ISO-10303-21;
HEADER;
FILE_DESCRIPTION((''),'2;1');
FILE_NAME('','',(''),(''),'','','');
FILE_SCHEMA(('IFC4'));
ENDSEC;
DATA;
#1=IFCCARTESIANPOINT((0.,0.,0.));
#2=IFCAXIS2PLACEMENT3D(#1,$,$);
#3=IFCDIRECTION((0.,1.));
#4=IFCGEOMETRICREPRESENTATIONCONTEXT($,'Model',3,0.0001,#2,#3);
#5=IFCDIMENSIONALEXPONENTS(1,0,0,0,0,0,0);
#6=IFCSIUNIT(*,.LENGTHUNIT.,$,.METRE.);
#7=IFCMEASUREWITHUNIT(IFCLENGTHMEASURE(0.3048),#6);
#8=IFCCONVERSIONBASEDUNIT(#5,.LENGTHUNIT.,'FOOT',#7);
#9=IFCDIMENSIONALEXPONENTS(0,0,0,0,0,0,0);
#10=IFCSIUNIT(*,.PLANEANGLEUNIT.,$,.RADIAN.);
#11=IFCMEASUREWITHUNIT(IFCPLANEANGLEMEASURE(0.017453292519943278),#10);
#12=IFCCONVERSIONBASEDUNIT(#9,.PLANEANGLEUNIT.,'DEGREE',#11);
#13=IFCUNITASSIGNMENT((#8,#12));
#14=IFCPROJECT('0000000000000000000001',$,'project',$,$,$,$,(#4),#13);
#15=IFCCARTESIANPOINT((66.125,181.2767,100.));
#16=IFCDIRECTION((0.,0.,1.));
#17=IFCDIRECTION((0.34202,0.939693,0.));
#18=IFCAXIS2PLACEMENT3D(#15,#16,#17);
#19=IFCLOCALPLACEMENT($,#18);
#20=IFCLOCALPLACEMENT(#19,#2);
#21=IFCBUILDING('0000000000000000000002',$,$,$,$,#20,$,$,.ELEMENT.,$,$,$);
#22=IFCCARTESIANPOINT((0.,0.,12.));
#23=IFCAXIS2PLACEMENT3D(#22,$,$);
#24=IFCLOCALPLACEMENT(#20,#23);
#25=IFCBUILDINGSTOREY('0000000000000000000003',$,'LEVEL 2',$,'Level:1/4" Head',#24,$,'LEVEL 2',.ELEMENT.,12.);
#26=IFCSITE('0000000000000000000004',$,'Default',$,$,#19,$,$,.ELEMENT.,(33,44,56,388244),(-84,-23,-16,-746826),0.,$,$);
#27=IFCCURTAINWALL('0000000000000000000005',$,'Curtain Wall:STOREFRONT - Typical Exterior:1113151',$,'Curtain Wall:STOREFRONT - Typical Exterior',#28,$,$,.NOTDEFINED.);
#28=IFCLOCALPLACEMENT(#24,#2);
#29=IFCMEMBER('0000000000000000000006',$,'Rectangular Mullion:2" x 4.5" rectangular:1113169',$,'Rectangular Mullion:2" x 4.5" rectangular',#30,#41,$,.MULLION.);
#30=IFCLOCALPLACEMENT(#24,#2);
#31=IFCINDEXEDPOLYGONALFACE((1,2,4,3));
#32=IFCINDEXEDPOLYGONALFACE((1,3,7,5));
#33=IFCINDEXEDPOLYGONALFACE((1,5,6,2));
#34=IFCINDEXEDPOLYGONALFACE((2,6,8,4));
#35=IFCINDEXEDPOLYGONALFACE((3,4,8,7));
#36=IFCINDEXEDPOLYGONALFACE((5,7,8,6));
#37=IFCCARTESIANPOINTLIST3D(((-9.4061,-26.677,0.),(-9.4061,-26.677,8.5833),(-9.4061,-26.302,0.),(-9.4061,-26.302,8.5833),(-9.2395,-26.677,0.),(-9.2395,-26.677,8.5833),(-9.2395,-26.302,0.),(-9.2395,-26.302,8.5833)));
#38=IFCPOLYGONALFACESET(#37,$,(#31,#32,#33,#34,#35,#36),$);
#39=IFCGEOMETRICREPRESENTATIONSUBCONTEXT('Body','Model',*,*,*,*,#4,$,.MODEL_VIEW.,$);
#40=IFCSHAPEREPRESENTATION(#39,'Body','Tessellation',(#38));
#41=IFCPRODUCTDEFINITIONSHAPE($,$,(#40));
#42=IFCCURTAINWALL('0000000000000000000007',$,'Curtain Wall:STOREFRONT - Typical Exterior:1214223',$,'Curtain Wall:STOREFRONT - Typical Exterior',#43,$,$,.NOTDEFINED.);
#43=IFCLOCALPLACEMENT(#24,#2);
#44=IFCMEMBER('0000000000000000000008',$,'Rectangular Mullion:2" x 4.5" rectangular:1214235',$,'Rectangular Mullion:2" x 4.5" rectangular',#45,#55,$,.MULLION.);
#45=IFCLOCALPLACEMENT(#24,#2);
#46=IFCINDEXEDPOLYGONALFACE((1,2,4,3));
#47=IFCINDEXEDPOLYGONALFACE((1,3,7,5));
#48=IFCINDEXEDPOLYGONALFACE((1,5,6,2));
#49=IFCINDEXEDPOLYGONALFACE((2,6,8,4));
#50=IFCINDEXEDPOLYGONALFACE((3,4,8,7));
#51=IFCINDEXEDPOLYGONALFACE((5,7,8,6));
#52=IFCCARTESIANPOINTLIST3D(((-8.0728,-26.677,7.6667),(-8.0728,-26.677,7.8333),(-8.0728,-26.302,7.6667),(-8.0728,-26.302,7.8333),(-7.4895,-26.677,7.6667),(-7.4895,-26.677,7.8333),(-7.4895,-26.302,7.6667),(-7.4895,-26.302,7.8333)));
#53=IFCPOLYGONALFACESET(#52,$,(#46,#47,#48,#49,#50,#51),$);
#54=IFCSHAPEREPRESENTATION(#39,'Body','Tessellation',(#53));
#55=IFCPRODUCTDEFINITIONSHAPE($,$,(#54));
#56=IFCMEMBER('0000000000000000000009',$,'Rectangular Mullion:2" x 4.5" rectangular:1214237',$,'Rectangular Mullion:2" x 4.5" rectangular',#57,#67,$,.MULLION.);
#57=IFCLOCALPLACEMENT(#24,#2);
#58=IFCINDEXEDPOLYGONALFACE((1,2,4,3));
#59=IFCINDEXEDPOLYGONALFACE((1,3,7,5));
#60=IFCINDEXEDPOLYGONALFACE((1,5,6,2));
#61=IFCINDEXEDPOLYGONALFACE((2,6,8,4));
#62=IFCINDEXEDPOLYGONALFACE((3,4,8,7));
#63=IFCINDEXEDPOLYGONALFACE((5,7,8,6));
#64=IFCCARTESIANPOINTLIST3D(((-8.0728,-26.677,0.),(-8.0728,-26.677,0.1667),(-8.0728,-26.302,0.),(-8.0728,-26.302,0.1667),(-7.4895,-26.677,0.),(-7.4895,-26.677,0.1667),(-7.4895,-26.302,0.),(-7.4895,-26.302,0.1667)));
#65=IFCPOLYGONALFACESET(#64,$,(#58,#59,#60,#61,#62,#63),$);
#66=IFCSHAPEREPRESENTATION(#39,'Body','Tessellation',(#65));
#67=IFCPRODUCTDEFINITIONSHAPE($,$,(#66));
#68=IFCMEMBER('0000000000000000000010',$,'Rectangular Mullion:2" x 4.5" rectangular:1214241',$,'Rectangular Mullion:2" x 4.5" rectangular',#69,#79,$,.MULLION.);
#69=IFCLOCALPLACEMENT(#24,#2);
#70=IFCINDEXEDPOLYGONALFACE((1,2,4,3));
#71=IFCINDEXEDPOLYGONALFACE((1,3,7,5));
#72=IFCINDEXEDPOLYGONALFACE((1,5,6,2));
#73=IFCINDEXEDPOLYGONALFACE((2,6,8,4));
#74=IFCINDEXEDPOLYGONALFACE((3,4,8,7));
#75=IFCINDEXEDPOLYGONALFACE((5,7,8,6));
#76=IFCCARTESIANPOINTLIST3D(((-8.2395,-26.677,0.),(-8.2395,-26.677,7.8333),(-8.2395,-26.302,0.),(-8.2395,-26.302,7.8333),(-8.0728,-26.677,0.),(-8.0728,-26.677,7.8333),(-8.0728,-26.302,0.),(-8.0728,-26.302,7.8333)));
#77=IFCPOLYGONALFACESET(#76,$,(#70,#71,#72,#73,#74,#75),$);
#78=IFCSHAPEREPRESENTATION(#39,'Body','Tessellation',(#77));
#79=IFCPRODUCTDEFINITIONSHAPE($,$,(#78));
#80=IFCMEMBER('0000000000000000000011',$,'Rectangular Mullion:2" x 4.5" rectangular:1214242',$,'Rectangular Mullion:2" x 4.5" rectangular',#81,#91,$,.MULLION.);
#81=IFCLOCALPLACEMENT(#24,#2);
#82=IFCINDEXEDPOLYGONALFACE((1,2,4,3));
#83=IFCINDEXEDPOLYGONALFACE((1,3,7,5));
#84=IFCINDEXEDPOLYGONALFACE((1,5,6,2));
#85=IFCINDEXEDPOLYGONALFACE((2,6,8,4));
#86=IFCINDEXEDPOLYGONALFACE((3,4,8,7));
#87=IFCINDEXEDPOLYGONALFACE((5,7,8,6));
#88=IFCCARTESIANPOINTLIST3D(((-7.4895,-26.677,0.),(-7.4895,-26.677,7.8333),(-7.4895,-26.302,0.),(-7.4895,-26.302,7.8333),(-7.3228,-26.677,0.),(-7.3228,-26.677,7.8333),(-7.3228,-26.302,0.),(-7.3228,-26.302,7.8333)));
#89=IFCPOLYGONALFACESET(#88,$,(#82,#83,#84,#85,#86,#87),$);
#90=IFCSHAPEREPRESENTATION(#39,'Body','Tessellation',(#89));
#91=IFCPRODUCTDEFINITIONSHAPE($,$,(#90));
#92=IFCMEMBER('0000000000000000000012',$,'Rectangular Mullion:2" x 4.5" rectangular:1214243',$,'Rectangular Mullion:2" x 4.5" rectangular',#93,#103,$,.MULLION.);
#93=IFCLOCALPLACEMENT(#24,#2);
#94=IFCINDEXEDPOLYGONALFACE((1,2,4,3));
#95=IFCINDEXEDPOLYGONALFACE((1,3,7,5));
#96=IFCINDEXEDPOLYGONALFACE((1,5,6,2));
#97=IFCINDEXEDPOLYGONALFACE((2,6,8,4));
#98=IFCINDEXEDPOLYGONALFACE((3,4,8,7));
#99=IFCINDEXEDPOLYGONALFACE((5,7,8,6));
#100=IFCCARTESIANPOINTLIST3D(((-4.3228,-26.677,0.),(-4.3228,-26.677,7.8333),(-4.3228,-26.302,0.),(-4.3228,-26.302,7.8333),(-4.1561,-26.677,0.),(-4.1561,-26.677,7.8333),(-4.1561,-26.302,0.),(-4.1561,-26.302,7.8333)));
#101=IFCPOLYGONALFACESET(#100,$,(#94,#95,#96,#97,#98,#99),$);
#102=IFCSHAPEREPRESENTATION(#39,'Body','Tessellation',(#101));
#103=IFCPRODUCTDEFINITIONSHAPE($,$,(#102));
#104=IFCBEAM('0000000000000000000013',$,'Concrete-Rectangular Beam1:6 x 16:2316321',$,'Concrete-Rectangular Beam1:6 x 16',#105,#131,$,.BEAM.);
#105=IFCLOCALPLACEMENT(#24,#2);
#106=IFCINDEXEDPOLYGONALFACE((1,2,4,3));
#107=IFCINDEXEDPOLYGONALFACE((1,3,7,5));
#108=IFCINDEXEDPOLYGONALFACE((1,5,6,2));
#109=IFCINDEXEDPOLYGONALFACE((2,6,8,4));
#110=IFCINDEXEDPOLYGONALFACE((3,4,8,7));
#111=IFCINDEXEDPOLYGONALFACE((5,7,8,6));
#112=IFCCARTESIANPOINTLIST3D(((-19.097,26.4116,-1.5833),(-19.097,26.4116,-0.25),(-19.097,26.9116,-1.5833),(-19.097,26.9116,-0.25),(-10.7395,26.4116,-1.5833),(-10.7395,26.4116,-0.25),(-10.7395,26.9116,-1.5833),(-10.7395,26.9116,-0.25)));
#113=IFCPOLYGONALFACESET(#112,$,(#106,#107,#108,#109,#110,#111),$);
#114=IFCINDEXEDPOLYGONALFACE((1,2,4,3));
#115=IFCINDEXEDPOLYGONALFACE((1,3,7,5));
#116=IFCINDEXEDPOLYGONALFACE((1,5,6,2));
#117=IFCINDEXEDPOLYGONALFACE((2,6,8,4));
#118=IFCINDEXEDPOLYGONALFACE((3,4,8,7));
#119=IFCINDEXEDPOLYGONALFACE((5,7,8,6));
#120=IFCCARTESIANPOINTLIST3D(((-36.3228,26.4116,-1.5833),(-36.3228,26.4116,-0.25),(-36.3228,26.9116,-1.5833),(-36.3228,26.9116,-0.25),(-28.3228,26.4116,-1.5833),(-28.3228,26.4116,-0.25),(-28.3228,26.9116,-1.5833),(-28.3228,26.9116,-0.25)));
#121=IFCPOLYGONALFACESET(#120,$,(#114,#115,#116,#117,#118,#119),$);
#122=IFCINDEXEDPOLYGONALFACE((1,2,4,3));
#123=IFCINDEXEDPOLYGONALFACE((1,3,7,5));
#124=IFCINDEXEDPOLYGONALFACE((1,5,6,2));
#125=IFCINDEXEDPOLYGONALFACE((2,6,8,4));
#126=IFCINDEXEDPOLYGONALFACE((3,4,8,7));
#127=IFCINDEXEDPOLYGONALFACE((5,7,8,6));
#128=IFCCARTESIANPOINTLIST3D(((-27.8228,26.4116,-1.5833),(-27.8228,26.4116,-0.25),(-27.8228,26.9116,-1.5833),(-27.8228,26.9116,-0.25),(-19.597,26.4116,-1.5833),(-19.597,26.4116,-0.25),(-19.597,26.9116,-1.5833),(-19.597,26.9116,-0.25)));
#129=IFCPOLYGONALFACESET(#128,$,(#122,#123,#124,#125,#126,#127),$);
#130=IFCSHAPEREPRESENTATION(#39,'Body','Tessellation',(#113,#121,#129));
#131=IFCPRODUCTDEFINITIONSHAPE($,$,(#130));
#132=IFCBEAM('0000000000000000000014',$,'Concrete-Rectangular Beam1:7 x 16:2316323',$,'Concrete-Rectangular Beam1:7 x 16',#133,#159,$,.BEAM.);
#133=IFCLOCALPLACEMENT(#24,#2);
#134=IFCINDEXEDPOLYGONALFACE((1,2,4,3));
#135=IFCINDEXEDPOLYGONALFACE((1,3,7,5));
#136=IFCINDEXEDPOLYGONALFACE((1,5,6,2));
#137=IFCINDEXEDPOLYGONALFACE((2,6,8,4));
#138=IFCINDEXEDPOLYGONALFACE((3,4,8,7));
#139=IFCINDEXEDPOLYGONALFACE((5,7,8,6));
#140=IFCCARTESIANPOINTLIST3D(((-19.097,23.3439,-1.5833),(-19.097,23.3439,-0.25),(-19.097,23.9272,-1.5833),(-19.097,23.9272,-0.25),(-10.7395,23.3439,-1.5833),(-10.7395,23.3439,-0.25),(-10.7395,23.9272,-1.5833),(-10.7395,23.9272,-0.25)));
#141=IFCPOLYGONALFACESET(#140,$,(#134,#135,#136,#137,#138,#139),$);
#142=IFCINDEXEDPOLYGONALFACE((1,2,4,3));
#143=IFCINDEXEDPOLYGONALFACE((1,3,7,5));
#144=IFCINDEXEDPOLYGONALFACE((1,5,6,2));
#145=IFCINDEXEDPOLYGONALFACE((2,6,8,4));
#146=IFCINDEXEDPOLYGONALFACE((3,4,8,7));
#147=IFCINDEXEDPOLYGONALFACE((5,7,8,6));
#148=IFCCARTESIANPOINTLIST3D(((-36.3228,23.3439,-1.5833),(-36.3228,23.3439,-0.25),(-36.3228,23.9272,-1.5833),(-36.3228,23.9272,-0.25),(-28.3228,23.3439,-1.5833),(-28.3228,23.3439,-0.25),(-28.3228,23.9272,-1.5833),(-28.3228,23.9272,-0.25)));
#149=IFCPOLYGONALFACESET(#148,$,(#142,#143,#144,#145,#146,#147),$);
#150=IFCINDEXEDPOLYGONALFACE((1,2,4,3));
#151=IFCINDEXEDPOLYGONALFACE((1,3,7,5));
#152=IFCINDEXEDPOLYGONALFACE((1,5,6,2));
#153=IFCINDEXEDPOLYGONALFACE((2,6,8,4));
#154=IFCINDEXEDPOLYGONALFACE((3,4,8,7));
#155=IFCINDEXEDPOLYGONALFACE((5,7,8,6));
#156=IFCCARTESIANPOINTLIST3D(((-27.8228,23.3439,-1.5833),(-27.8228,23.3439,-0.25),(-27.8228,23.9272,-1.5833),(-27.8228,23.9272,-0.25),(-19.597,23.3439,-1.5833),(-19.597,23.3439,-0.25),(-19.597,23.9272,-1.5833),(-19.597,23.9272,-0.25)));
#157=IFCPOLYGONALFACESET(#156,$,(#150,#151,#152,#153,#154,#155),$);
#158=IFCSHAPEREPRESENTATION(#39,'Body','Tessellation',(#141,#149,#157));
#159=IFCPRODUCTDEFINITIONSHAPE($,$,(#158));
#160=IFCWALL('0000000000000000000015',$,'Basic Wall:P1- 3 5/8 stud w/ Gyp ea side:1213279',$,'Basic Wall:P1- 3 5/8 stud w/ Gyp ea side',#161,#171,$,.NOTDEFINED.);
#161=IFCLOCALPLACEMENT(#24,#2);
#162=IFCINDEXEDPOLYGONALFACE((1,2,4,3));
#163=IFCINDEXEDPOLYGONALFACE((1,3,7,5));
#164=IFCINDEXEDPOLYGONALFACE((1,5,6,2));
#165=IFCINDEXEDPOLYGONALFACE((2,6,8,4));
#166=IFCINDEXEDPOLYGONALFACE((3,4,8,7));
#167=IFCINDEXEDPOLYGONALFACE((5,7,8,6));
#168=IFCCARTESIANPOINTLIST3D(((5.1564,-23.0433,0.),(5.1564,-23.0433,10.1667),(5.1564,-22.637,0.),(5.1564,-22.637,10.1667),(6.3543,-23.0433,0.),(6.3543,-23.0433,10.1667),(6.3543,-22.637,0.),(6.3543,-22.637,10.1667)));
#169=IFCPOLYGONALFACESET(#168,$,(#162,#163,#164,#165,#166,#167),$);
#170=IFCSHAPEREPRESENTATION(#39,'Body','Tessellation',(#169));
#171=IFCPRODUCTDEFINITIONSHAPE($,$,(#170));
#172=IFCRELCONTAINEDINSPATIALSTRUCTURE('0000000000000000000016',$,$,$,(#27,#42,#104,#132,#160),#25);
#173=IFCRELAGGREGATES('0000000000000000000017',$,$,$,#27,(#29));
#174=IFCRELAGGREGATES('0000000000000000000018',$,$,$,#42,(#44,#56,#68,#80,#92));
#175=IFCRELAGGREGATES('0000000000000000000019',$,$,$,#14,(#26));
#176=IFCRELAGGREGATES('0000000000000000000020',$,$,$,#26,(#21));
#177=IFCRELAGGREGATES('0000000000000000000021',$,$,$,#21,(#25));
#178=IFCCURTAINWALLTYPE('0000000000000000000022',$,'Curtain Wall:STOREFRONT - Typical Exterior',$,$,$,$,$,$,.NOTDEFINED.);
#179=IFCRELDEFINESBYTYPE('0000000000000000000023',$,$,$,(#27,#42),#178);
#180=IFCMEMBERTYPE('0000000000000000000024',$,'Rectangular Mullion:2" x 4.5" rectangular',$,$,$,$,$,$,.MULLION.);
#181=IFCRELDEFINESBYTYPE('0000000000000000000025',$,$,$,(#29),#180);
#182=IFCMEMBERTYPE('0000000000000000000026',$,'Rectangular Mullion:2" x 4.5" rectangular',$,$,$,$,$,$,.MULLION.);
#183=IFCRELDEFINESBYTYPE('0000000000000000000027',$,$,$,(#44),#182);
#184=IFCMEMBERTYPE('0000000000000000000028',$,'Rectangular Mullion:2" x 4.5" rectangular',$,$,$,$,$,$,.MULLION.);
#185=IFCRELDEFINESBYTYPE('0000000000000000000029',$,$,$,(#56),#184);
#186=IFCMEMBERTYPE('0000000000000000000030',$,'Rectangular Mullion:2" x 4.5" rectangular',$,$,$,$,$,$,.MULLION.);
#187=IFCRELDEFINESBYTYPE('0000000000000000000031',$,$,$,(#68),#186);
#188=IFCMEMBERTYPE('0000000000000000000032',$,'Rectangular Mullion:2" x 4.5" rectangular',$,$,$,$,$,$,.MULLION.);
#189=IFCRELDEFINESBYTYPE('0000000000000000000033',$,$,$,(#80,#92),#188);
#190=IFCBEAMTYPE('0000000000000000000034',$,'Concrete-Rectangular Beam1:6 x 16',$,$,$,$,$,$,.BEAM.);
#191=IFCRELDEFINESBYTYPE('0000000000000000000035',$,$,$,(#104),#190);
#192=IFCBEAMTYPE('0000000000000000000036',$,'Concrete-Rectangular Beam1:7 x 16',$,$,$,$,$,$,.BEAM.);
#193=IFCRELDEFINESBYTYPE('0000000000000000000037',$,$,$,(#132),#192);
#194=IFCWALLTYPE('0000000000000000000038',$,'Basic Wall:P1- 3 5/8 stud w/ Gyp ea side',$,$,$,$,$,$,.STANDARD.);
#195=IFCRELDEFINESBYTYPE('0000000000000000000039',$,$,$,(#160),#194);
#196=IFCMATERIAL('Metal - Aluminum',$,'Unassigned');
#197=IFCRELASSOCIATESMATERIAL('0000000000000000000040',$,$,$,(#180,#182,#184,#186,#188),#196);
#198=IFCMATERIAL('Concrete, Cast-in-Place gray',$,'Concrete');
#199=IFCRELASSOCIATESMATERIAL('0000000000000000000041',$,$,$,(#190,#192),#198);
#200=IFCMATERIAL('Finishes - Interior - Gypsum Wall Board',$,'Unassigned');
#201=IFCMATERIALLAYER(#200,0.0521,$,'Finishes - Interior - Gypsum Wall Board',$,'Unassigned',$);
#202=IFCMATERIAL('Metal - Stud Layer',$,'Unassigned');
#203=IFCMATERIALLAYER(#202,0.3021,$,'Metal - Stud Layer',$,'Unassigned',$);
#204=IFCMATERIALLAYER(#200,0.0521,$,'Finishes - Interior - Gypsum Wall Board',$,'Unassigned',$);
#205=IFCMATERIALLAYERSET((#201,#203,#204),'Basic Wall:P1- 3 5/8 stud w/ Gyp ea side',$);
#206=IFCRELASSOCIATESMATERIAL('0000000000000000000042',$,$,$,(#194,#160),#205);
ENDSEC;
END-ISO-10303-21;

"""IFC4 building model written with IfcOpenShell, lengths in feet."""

from ifc_helpers import new_model, entity, si_unit, converted_unit, direction, frame, frame_2d, origin, origin_2d_with_axis, place, context, subcontext, project, spatial, rectangle, extrude, source, transform, mapped, material, layer, layer_set, layer_usage, material_profile, profile_set, type_object, type_shapes, element, aggregate, save


model = new_model("IFC4")

# Units and contexts
model_context = context("Model", 3, precision=0.0001, world=origin(), true_north=direction((0.0, 1.0)))
body_context = subcontext(model_context, "Body", "Model", "MODEL_VIEW")
ifc_project = project(units=[converted_unit("LENGTHUNIT", "FOOT", entity("IfcLengthMeasure", 0.3048), si_unit("LENGTHUNIT", "METRE"), dimensions=[1, 0, 0, 0, 0, 0, 0]), converted_unit("PLANEANGLEUNIT", "DEGREE", entity("IfcPlaneAngleMeasure", 0.017453292519943278), si_unit("PLANEANGLEUNIT", "RADIAN"), dimensions=[0, 0, 0, 0, 0, 0, 0])], contexts=[model_context])

# Site, building, storey
site_placement = place(None, frame((66.125, 181.2767, 100.0), z_axis=(0.0, 0.0, 1.0), x_axis=(0.34202, 0.939693, 0.0)))
site = spatial("IfcSite", under=ifc_project, at=site_placement, Name="Default", CompositionType="ELEMENT", RefLatitude=(33, 44, 56, 388244), RefLongitude=(-84, -23, -16, -746826), RefElevation=0.0)
building_placement = place(site_placement, origin())
building = spatial("IfcBuilding", under=site, at=building_placement, CompositionType="ELEMENT")
storey_placement = place(building_placement, frame((0.0, 0.0, 12.0)))
storey = spatial("IfcBuildingStorey", under=building, at=storey_placement, Name="LEVEL 2", ObjectType="Level:1/4\" Head", LongName="LEVEL 2", CompositionType="ELEMENT", Elevation=12.0)

# Curtain wall, member
curtain_wall_type = type_object("IfcCurtainWallType", Name="Curtain Wall:STOREFRONT - Typical Exterior", PredefinedType="NOTDEFINED")
curtain_wall_1_placement = place(storey_placement, frame((0.0, 0.0, -12.0)))
curtain_wall_1 = element("IfcCurtainWall", 1, at=curtain_wall_1_placement, inside=storey, type_object=curtain_wall_type, Name="Curtain Wall:STOREFRONT - Typical Exterior:1113151", ObjectType="Curtain Wall:STOREFRONT - Typical Exterior", PredefinedType="NOTDEFINED")
ifc_material_1 = material(Name="Metal - Aluminum", Category="Unassigned")
ifc_material_profile_1 = material_profile(ifc_material_1, rectangle(XDim=0.1667, YDim=0.375, at=origin_2d_with_axis()), Name="2\" x 4.5\" rectangular")
ifc_profile_set_1 = profile_set([ifc_material_profile_1], Name="2\" x 4.5\" rectangular")
member_type_1 = type_object("IfcMemberType", Name="Rectangular Mullion:2\" x 4.5\" rectangular", PredefinedType="MULLION", material=ifc_profile_set_1)
shared_shape_1 = source(origin(), body_context, "Body", "SweptSolid", [
    extrude(rectangle(XDim=0.1667, YDim=0.375, at=origin_2d_with_axis()), frame((-0.0833, 0.0, -8.5833), z_axis=(0.0, 0.0, 1.0), x_axis=(-1.0, 0.0, 0.0)), (0.0, 0.0, 1.0), 8.5833),
])
type_shapes(member_type_1, [shared_shape_1])
member_1_placement = place(curtain_wall_1_placement, frame((-9.2395, -26.4895, 20.5833)))
member_1 = element("IfcMember", 2, at=member_1_placement, type_object=member_type_1, Name="Rectangular Mullion:2\" x 4.5\" rectangular:1113169", ObjectType="Rectangular Mullion:2\" x 4.5\" rectangular", PredefinedType="MULLION", context=body_context, shape_type="MappedRepresentation", body=[
    mapped(shared_shape_1, transform((0.0, 0.0, 0.0), scale=1.0)),
])
aggregate(curtain_wall_1, [member_1])

# Curtain wall, members
curtain_wall_2_placement = place(storey_placement, frame((0.0, 0.0, -12.0)))
curtain_wall_2 = element("IfcCurtainWall", 3, at=curtain_wall_2_placement, inside=storey, type_object=curtain_wall_type, Name="Curtain Wall:STOREFRONT - Typical Exterior:1214223", ObjectType="Curtain Wall:STOREFRONT - Typical Exterior", PredefinedType="NOTDEFINED")
member_type_2 = type_object("IfcMemberType", Name="Rectangular Mullion:2\" x 4.5\" rectangular", PredefinedType="MULLION", material=ifc_profile_set_1)
shared_shape_2 = source(origin(), body_context, "Body", "SweptSolid", [
    extrude(rectangle(XDim=0.1667, YDim=0.375, at=origin_2d_with_axis()), frame((-0.0833, 0.0, -0.5833), z_axis=(0.0, 0.0, 1.0), x_axis=(-1.0, 0.0, 0.0)), (0.0, 0.0, 1.0), 0.5833),
])
type_shapes(member_type_2, [shared_shape_2])
member_2_placement = place(curtain_wall_2_placement, frame((-7.4895, -26.4895, 19.8333), z_axis=(1.0, 0.0, 0.0), x_axis=(0.0, 0.0, 1.0)))
member_2 = element("IfcMember", 4, at=member_2_placement, type_object=member_type_2, Name="Rectangular Mullion:2\" x 4.5\" rectangular:1214235", ObjectType="Rectangular Mullion:2\" x 4.5\" rectangular", PredefinedType="MULLION", context=body_context, shape_type="MappedRepresentation", body=[
    mapped(shared_shape_2, transform((0.0, 0.0, 0.0), scale=1.0)),
])
member_type_3 = type_object("IfcMemberType", Name="Rectangular Mullion:2\" x 4.5\" rectangular", PredefinedType="MULLION", material=ifc_profile_set_1)
shared_shape_3 = source(origin(), body_context, "Body", "SweptSolid", [
    extrude(rectangle(XDim=0.1667, YDim=0.375, at=origin_2d_with_axis()), frame((-0.0833, 0.0, -0.5833), z_axis=(0.0, 0.0, 1.0), x_axis=(-1.0, 0.0, 0.0)), (0.0, 0.0, 1.0), 0.5833),
])
type_shapes(member_type_3, [shared_shape_3])
member_3_placement = place(curtain_wall_2_placement, frame((-8.0728, -26.4895, 12.0), z_axis=(-1.0, 0.0, 0.0), x_axis=(0.0, 0.0, -1.0)))
member_3 = element("IfcMember", 5, at=member_3_placement, type_object=member_type_3, Name="Rectangular Mullion:2\" x 4.5\" rectangular:1214237", ObjectType="Rectangular Mullion:2\" x 4.5\" rectangular", PredefinedType="MULLION", context=body_context, shape_type="MappedRepresentation", body=[
    mapped(shared_shape_3, transform((0.0, 0.0, 0.0), scale=1.0)),
])
member_type_4 = type_object("IfcMemberType", Name="Rectangular Mullion:2\" x 4.5\" rectangular", PredefinedType="MULLION", material=ifc_profile_set_1)
shared_shape_4 = source(origin(), body_context, "Body", "SweptSolid", [
    extrude(rectangle(XDim=0.1667, YDim=0.375, at=origin_2d_with_axis()), frame((-0.0833, 0.0, -7.8333), z_axis=(0.0, 0.0, 1.0), x_axis=(-1.0, 0.0, 0.0)), (0.0, 0.0, 1.0), 7.8333),
])
type_shapes(member_type_4, [shared_shape_4])
member_4_placement = place(curtain_wall_2_placement, frame((-8.2395, -26.4895, 19.8333), z_axis=(0.0, 0.0, 1.0), x_axis=(-1.0, 0.0, 0.0)))
member_4 = element("IfcMember", 6, at=member_4_placement, type_object=member_type_4, Name="Rectangular Mullion:2\" x 4.5\" rectangular:1214241", ObjectType="Rectangular Mullion:2\" x 4.5\" rectangular", PredefinedType="MULLION", context=body_context, shape_type="MappedRepresentation", body=[
    mapped(shared_shape_4, transform((0.0, 0.0, 0.0), scale=1.0)),
])
member_type_5 = type_object("IfcMemberType", Name="Rectangular Mullion:2\" x 4.5\" rectangular", PredefinedType="MULLION", material=ifc_profile_set_1)
shared_shape_5 = source(origin(), body_context, "Body", "SweptSolid", [
    extrude(rectangle(XDim=0.1667, YDim=0.375, at=frame_2d((0.0, 0.0), x_axis=(1.0, 0.0))), frame((0.0, 0.0, -7.8333), z_axis=(0.0, 0.0, 1.0), x_axis=(-1.0, 0.0, 0.0)), (0.0, 0.0, 1.0), 7.8333),
])
type_shapes(member_type_5, [shared_shape_5])
member_5_placement = place(curtain_wall_2_placement, frame((-7.4061, -26.4895, 12.0), z_axis=(0.0, 0.0, -1.0), x_axis=(1.0, 0.0, 0.0)))
member_5 = element("IfcMember", 7, at=member_5_placement, type_object=member_type_5, Name="Rectangular Mullion:2\" x 4.5\" rectangular:1214242", ObjectType="Rectangular Mullion:2\" x 4.5\" rectangular", PredefinedType="MULLION", context=body_context, shape_type="MappedRepresentation", body=[
    mapped(shared_shape_5, transform((0.0, 0.0, 0.0), scale=1.0)),
])
member_6_placement = place(curtain_wall_2_placement, frame((-4.2395, -26.4895, 12.0), z_axis=(0.0, 0.0, -1.0), x_axis=(1.0, 0.0, 0.0)))
member_6 = element("IfcMember", 8, at=member_6_placement, type_object=member_type_5, Name="Rectangular Mullion:2\" x 4.5\" rectangular:1214243", ObjectType="Rectangular Mullion:2\" x 4.5\" rectangular", PredefinedType="MULLION", context=body_context, shape_type="MappedRepresentation", body=[
    mapped(shared_shape_5, transform((0.0, 0.0, 0.0), scale=1.0)),
])

# Beams
ifc_material_2 = material(Name="Concrete, Cast-in-Place gray", Category="Concrete")
ifc_material_profile_2 = material_profile(ifc_material_2, rectangle(XDim=1.3333, YDim=0.5, at=frame_2d((0.0, 0.0), x_axis=(1.0, 0.0))), Name="6 x 16")
ifc_profile_set_2 = profile_set([ifc_material_profile_2], Name="6 x 16")
beam_type_1 = type_object("IfcBeamType", Name="Concrete-Rectangular Beam1:6 x 16", PredefinedType="BEAM", material=ifc_profile_set_2)
shared_shape_6 = source(origin(), body_context, "Body", "SweptSolid", [
    extrude(rectangle(XDim=1.3333, YDim=0.5, at=frame_2d((0.0, 0.0), x_axis=(1.0, 0.0))), frame((-19.097, 26.6616, 11.0833), z_axis=(1.0, 0.0, 0.0), x_axis=(0.0, 0.0, -1.0)), (0.0, 0.0, 1.0), 8.3575),
    extrude(rectangle(XDim=1.3333, YDim=0.5, at=frame_2d((0.0, 0.0), x_axis=(1.0, 0.0))), frame((-36.3228, 26.6616, 11.0833), z_axis=(1.0, 0.0, 0.0), x_axis=(0.0, 0.0, -1.0)), (0.0, 0.0, 1.0), 8.0),
    extrude(rectangle(XDim=1.3333, YDim=0.5, at=frame_2d((0.0, 0.0), x_axis=(1.0, 0.0))), frame((-27.8228, 26.6616, 11.0833), z_axis=(1.0, 0.0, 0.0), x_axis=(0.0, 0.0, -1.0)), (0.0, 0.0, 1.0), 8.2258),
])
type_shapes(beam_type_1, [shared_shape_6])
beam_1_placement = place(storey_placement, frame((0.0, 0.0, -12.0)))
element("IfcBeam", 9, at=beam_1_placement, inside=storey, type_object=beam_type_1, Name="Concrete-Rectangular Beam1:6 x 16:2316321", ObjectType="Concrete-Rectangular Beam1:6 x 16", PredefinedType="BEAM", context=body_context, shape_type="MappedRepresentation", body=[
    mapped(shared_shape_6, transform((0.0, 0.0, 0.0), scale=1.0)),
])
ifc_material_profile_3 = material_profile(ifc_material_2, rectangle(XDim=1.3333, YDim=0.5833, at=frame_2d((0.0, 0.0), x_axis=(1.0, 0.0))), Name="7 x 16")
ifc_profile_set_3 = profile_set([ifc_material_profile_3], Name="7 x 16")
beam_type_2 = type_object("IfcBeamType", Name="Concrete-Rectangular Beam1:7 x 16", PredefinedType="BEAM", material=ifc_profile_set_3)
shared_shape_7 = source(origin(), body_context, "Body", "SweptSolid", [
    extrude(rectangle(XDim=1.3333, YDim=0.5833, at=frame_2d((0.0, 0.0), x_axis=(1.0, 0.0))), frame((-19.097, 23.6355, 11.0833), z_axis=(1.0, 0.0, 0.0), x_axis=(0.0, 0.0, -1.0)), (0.0, 0.0, 1.0), 8.3575),
    extrude(rectangle(XDim=1.3333, YDim=0.5833, at=frame_2d((0.0, 0.0), x_axis=(1.0, 0.0))), frame((-36.3228, 23.6355, 11.0833), z_axis=(1.0, 0.0, 0.0), x_axis=(0.0, 0.0, -1.0)), (0.0, 0.0, 1.0), 8.0),
    extrude(rectangle(XDim=1.3333, YDim=0.5833, at=frame_2d((0.0, 0.0), x_axis=(1.0, 0.0))), frame((-27.8228, 23.6355, 11.0833), z_axis=(1.0, 0.0, 0.0), x_axis=(0.0, 0.0, -1.0)), (0.0, 0.0, 1.0), 8.2258),
])
type_shapes(beam_type_2, [shared_shape_7])
beam_2_placement = place(storey_placement, frame((0.0, 0.0, -12.0)))
element("IfcBeam", 10, at=beam_2_placement, inside=storey, type_object=beam_type_2, Name="Concrete-Rectangular Beam1:7 x 16:2316323", ObjectType="Concrete-Rectangular Beam1:7 x 16", PredefinedType="BEAM", context=body_context, shape_type="MappedRepresentation", body=[
    mapped(shared_shape_7, transform((0.0, 0.0, 0.0), scale=1.0)),
])

# Wall
ifc_material_3 = material(Name="Finishes - Interior - Gypsum Wall Board", Category="Unassigned")
ifc_layer_1 = layer(ifc_material_3, 0.0521, Name="Finishes - Interior - Gypsum Wall Board", Category="Unassigned")
ifc_material_4 = material(Name="Metal - Stud Layer", Category="Unassigned")
ifc_layer_2 = layer(ifc_material_4, 0.3021, Name="Metal - Stud Layer", Category="Unassigned")
ifc_layer_3 = layer(ifc_material_3, 0.0521, Name="Finishes - Interior - Gypsum Wall Board", Category="Unassigned")
ifc_layer_set_1 = layer_set([ifc_layer_1, ifc_layer_2, ifc_layer_3], Name="Basic Wall:P1- 3 5/8 stud w/ Gyp ea side")
ifc_layer_usage_1 = layer_usage(ifc_layer_set_1, "AXIS2", "NEGATIVE", 0.2031)
wall_type_1 = type_object("IfcWallType", Name="Basic Wall:P1- 3 5/8 stud w/ Gyp ea side", PredefinedType="STANDARD", material=ifc_layer_set_1)
wall_1_placement = place(storey_placement, frame((5.1564, -22.8402, 0.0)))
element("IfcWall", 11, at=wall_1_placement, inside=storey, type_object=wall_type_1, material=ifc_layer_usage_1, Name="Basic Wall:P1- 3 5/8 stud w/ Gyp ea side:1213279", ObjectType="Basic Wall:P1- 3 5/8 stud w/ Gyp ea side", PredefinedType="NOTDEFINED", context=body_context, shape_type="SweptSolid", body=[
    extrude(rectangle(XDim=1.1979, YDim=0.4062, at=frame_2d((0.599, 0.0), x_axis=(-1.0, 0.0))), origin(), (0.0, 0.0, 1.0), 10.1667),
])

aggregate(curtain_wall_2, [member_2, member_3, member_4, member_5, member_6])

save(model, "model.ifc")
